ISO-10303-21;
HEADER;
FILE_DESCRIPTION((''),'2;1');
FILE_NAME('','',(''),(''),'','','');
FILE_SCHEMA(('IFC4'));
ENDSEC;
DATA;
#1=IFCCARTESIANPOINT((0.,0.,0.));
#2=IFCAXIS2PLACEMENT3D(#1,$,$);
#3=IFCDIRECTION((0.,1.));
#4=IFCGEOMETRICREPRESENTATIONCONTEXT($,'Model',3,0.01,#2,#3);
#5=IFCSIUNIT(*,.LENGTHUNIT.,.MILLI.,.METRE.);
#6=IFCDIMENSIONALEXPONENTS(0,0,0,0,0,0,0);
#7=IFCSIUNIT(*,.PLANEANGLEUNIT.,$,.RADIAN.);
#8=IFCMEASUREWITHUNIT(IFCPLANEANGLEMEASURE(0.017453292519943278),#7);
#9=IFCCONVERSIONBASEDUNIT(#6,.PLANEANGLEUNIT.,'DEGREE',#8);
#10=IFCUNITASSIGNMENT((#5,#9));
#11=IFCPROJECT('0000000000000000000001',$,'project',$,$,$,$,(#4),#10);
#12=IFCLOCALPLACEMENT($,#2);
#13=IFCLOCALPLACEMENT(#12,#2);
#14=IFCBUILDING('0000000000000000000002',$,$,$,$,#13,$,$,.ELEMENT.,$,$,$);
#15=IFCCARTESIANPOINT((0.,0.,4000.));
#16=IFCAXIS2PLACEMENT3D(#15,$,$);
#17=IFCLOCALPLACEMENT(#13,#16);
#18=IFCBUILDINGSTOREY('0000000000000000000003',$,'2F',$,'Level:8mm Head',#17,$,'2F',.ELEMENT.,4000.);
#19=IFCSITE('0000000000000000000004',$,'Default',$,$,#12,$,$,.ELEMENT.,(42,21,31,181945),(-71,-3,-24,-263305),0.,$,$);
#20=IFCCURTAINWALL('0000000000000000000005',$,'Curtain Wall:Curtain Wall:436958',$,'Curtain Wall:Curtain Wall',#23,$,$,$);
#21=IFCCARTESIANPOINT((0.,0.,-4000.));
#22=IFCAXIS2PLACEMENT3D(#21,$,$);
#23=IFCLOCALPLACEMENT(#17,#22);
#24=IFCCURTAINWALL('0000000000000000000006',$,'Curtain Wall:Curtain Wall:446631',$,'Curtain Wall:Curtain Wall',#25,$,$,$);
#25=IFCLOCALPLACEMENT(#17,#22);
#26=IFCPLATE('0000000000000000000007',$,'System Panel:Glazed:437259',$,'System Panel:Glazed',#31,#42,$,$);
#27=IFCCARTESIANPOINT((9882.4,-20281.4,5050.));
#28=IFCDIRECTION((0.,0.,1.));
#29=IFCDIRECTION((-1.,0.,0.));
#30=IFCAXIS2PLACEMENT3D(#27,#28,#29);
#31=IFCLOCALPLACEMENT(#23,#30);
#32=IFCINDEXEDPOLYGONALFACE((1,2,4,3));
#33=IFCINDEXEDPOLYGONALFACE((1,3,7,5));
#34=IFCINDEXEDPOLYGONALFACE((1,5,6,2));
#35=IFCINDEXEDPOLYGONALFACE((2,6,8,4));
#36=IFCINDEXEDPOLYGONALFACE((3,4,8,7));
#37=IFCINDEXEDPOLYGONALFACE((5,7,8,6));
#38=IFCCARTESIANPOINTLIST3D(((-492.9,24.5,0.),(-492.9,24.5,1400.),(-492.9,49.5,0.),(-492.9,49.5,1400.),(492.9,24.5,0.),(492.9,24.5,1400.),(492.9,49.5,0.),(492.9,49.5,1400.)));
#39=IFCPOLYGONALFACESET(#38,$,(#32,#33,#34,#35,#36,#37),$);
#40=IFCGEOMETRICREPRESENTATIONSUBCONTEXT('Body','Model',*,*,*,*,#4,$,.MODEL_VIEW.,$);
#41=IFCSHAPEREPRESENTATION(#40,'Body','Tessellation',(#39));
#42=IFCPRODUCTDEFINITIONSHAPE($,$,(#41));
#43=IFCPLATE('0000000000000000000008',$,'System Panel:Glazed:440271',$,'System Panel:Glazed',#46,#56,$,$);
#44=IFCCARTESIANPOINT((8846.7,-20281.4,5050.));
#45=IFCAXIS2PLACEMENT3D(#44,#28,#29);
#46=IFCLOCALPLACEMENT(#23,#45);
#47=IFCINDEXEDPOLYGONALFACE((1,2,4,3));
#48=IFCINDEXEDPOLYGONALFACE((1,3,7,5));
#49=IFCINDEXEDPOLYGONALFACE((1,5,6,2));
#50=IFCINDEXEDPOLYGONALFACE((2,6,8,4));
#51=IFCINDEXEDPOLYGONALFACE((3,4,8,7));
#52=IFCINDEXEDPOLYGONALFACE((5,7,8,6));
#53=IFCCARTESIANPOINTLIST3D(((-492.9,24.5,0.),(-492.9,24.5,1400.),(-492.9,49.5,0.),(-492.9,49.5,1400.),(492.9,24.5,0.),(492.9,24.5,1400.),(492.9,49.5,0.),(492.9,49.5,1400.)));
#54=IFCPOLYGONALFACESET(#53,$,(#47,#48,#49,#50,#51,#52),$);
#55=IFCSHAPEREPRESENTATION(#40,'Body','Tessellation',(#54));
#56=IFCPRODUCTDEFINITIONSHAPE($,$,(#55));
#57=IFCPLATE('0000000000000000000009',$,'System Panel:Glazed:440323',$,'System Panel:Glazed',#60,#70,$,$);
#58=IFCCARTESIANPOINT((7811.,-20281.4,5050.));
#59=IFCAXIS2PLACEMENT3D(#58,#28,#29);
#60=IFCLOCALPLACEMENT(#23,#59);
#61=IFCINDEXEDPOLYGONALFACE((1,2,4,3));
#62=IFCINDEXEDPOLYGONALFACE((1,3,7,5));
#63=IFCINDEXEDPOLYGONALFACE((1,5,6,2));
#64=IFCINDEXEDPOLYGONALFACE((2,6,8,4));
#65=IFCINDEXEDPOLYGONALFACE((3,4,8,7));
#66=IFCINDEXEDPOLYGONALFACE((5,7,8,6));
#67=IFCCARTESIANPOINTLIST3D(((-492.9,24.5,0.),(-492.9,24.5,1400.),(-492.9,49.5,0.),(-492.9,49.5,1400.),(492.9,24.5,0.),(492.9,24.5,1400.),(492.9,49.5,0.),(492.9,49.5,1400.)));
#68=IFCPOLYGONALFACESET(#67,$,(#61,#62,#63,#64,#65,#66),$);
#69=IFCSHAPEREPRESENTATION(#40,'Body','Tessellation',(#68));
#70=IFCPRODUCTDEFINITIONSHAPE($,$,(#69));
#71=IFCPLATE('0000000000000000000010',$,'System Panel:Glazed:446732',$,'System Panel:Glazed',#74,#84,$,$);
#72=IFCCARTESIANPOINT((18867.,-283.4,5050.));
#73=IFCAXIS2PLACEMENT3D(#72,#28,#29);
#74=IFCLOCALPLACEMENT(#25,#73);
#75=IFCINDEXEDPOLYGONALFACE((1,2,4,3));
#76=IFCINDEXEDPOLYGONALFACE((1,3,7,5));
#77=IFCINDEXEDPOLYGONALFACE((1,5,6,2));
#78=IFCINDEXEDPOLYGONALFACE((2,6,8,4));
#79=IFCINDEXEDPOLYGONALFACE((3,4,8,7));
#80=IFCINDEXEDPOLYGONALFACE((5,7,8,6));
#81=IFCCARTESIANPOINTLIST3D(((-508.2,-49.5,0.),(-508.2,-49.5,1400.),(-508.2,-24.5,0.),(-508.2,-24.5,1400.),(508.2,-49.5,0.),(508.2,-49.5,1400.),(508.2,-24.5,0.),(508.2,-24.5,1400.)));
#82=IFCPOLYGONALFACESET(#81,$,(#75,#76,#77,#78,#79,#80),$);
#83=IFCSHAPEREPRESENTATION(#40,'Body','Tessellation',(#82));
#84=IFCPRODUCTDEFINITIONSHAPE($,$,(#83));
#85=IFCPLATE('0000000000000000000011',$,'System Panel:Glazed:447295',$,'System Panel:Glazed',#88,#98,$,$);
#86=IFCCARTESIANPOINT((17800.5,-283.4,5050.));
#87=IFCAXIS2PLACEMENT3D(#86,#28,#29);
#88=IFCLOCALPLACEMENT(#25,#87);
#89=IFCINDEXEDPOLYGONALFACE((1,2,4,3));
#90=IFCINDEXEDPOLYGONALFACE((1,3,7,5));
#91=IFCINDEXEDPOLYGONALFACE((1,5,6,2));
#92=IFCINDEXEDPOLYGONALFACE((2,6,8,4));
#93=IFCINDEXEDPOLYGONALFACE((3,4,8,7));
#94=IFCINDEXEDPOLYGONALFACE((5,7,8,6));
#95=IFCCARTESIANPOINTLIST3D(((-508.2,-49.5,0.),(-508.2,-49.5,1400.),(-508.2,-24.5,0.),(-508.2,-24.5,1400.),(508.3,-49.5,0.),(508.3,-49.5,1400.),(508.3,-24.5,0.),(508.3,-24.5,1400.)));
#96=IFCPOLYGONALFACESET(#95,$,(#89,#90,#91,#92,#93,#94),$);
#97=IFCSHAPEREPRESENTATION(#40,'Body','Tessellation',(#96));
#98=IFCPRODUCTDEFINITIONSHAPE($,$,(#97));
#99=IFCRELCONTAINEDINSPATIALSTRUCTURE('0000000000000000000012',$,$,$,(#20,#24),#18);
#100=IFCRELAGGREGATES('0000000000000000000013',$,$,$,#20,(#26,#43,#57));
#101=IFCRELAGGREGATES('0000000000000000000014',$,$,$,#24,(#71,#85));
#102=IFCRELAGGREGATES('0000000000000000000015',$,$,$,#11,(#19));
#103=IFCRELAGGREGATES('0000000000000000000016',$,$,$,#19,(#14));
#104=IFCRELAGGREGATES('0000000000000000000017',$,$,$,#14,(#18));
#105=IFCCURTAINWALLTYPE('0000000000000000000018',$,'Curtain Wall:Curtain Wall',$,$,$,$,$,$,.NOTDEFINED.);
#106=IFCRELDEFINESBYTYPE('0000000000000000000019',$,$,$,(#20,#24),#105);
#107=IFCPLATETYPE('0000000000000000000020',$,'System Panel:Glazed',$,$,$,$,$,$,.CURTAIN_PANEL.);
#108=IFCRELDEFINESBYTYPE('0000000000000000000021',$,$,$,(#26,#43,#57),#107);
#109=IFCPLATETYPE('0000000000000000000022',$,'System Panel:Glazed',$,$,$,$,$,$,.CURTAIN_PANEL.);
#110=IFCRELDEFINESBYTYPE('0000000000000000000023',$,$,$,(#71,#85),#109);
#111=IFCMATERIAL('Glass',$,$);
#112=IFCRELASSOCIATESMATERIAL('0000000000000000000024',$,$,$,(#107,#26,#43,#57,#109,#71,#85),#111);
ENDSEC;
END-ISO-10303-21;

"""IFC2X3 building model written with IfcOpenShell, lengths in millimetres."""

from ifc_helpers import new_model, entity, si_unit, converted_unit, direction, frame, frame_2d, origin, origin_2d_with_axis, place, context, subcontext, project, spatial, rectangle, extrude, source, transform, mapped, material, type_object, type_shapes, element, aggregate, save


model = new_model("IFC2X3")

# Units and contexts
model_context = context("Model", 3, precision=0.01, world=origin(), true_north=direction((0.0, 1.0)))
body_context = subcontext(model_context, "Body", "Model", "MODEL_VIEW")
ifc_project = project(units=[si_unit("LENGTHUNIT", "METRE", prefix="MILLI"), converted_unit("PLANEANGLEUNIT", "DEGREE", entity("IfcPlaneAngleMeasure", 0.017453292519943278), si_unit("PLANEANGLEUNIT", "RADIAN"), dimensions=[0, 0, 0, 0, 0, 0, 0])], contexts=[model_context])

# Site, building, storey
site_placement = place(None, origin())
site = spatial("IfcSite", under=ifc_project, at=site_placement, Name="Default", CompositionType="ELEMENT", RefLatitude=(42, 21, 31, 181945), RefLongitude=(-71, -3, -24, -263305), RefElevation=0.0)
building_placement = place(site_placement, origin())
building = spatial("IfcBuilding", under=site, at=building_placement, CompositionType="ELEMENT")
storey_placement = place(building_placement, frame((0.0, 0.0, 4000.0)))
storey = spatial("IfcBuildingStorey", under=building, at=storey_placement, Name="2F", ObjectType="Level:8mm Head", LongName="2F", CompositionType="ELEMENT", Elevation=4000.0)

# Curtain walls
curtain_wall_type = type_object("IfcCurtainWallType", Name="Curtain Wall:Curtain Wall", PredefinedType="NOTDEFINED")
curtain_wall_1_placement = place(storey_placement, frame((0.0, 0.0, -4000.0)))
curtain_wall_1 = element("IfcCurtainWall", 1, at=curtain_wall_1_placement, inside=storey, type_object=curtain_wall_type, Name="Curtain Wall:Curtain Wall:436958", ObjectType="Curtain Wall:Curtain Wall")
curtain_wall_2_placement = place(storey_placement, frame((0.0, 0.0, -4000.0)))
curtain_wall_2 = element("IfcCurtainWall", 2, at=curtain_wall_2_placement, inside=storey, type_object=curtain_wall_type, Name="Curtain Wall:Curtain Wall:446631", ObjectType="Curtain Wall:Curtain Wall")

# Plates
ifc_material_1 = material(Name="Glass")
plate_type_1 = type_object("IfcPlateType", Name="System Panel:Glazed", PredefinedType="CURTAIN_PANEL", material=ifc_material_1)
shared_shape_1 = source(origin(), body_context, "Body", "SweptSolid", [
    extrude(rectangle(XDim=25.0, YDim=985.7, at=origin_2d_with_axis()), frame((0.0, 37.0, 0.0), z_axis=(0.0, 0.0, 1.0), x_axis=(0.0, 1.0, 0.0)), (0.0, 0.0, 1.0), 1400.0),
])
type_shapes(plate_type_1, [shared_shape_1])
plate_1_placement = place(curtain_wall_1_placement, frame((9882.4, -20281.4, 5050.0), z_axis=(0.0, 0.0, 1.0), x_axis=(-1.0, 0.0, 0.0)))
plate_1 = element("IfcPlate", 3, at=plate_1_placement, type_object=plate_type_1, material=ifc_material_1, Name="System Panel:Glazed:437259", ObjectType="System Panel:Glazed", context=body_context, shape_type="MappedRepresentation", body=[
    mapped(shared_shape_1, transform((0.0, 0.0, 0.0), scale=1.0)),
])
plate_2_placement = place(curtain_wall_1_placement, frame((8846.7, -20281.4, 5050.0), z_axis=(0.0, 0.0, 1.0), x_axis=(-1.0, 0.0, 0.0)))
plate_2 = element("IfcPlate", 4, at=plate_2_placement, type_object=plate_type_1, material=ifc_material_1, Name="System Panel:Glazed:440271", ObjectType="System Panel:Glazed", context=body_context, shape_type="MappedRepresentation", body=[
    mapped(shared_shape_1, transform((0.0, 0.0, 0.0), scale=1.0)),
])
plate_3_placement = place(curtain_wall_1_placement, frame((7811.0, -20281.4, 5050.0), z_axis=(0.0, 0.0, 1.0), x_axis=(-1.0, 0.0, 0.0)))
plate_3 = element("IfcPlate", 5, at=plate_3_placement, type_object=plate_type_1, material=ifc_material_1, Name="System Panel:Glazed:440323", ObjectType="System Panel:Glazed", context=body_context, shape_type="MappedRepresentation", body=[
    mapped(shared_shape_1, transform((0.0, 0.0, 0.0), scale=1.0)),
])
aggregate(curtain_wall_1, [plate_1, plate_2, plate_3])
plate_type_2 = type_object("IfcPlateType", Name="System Panel:Glazed", PredefinedType="CURTAIN_PANEL", material=ifc_material_1)
shared_shape_2 = source(origin(), body_context, "Body", "SweptSolid", [
    extrude(rectangle(XDim=25.0, YDim=1016.5, at=frame_2d((0.0, 0.0), x_axis=(1.0, 0.0))), frame((0.0, -37.0, 0.0), z_axis=(0.0, 0.0, 1.0), x_axis=(0.0, 1.0, 0.0)), (0.0, 0.0, 1.0), 1400.0),
])
type_shapes(plate_type_2, [shared_shape_2])
plate_4_placement = place(curtain_wall_2_placement, frame((18867.0, -283.4, 5050.0), z_axis=(0.0, 0.0, 1.0), x_axis=(-1.0, 0.0, 0.0)))
plate_4 = element("IfcPlate", 6, at=plate_4_placement, type_object=plate_type_2, material=ifc_material_1, Name="System Panel:Glazed:446732", ObjectType="System Panel:Glazed", context=body_context, shape_type="MappedRepresentation", body=[
    mapped(shared_shape_2, transform((0.0, 0.0, 0.0), scale=1.0)),
])
plate_5_placement = place(curtain_wall_2_placement, frame((17800.5, -283.4, 5050.0), z_axis=(0.0, 0.0, 1.0), x_axis=(-1.0, 0.0, 0.0)))
plate_5 = element("IfcPlate", 7, at=plate_5_placement, type_object=plate_type_2, material=ifc_material_1, Name="System Panel:Glazed:447295", ObjectType="System Panel:Glazed", context=body_context, shape_type="MappedRepresentation", body=[
    mapped(shared_shape_2, transform((0.0, 0.0, 0.0), scale=1.0)),
])
aggregate(curtain_wall_2, [plate_4, plate_5])

save(model, "model.ifc")
